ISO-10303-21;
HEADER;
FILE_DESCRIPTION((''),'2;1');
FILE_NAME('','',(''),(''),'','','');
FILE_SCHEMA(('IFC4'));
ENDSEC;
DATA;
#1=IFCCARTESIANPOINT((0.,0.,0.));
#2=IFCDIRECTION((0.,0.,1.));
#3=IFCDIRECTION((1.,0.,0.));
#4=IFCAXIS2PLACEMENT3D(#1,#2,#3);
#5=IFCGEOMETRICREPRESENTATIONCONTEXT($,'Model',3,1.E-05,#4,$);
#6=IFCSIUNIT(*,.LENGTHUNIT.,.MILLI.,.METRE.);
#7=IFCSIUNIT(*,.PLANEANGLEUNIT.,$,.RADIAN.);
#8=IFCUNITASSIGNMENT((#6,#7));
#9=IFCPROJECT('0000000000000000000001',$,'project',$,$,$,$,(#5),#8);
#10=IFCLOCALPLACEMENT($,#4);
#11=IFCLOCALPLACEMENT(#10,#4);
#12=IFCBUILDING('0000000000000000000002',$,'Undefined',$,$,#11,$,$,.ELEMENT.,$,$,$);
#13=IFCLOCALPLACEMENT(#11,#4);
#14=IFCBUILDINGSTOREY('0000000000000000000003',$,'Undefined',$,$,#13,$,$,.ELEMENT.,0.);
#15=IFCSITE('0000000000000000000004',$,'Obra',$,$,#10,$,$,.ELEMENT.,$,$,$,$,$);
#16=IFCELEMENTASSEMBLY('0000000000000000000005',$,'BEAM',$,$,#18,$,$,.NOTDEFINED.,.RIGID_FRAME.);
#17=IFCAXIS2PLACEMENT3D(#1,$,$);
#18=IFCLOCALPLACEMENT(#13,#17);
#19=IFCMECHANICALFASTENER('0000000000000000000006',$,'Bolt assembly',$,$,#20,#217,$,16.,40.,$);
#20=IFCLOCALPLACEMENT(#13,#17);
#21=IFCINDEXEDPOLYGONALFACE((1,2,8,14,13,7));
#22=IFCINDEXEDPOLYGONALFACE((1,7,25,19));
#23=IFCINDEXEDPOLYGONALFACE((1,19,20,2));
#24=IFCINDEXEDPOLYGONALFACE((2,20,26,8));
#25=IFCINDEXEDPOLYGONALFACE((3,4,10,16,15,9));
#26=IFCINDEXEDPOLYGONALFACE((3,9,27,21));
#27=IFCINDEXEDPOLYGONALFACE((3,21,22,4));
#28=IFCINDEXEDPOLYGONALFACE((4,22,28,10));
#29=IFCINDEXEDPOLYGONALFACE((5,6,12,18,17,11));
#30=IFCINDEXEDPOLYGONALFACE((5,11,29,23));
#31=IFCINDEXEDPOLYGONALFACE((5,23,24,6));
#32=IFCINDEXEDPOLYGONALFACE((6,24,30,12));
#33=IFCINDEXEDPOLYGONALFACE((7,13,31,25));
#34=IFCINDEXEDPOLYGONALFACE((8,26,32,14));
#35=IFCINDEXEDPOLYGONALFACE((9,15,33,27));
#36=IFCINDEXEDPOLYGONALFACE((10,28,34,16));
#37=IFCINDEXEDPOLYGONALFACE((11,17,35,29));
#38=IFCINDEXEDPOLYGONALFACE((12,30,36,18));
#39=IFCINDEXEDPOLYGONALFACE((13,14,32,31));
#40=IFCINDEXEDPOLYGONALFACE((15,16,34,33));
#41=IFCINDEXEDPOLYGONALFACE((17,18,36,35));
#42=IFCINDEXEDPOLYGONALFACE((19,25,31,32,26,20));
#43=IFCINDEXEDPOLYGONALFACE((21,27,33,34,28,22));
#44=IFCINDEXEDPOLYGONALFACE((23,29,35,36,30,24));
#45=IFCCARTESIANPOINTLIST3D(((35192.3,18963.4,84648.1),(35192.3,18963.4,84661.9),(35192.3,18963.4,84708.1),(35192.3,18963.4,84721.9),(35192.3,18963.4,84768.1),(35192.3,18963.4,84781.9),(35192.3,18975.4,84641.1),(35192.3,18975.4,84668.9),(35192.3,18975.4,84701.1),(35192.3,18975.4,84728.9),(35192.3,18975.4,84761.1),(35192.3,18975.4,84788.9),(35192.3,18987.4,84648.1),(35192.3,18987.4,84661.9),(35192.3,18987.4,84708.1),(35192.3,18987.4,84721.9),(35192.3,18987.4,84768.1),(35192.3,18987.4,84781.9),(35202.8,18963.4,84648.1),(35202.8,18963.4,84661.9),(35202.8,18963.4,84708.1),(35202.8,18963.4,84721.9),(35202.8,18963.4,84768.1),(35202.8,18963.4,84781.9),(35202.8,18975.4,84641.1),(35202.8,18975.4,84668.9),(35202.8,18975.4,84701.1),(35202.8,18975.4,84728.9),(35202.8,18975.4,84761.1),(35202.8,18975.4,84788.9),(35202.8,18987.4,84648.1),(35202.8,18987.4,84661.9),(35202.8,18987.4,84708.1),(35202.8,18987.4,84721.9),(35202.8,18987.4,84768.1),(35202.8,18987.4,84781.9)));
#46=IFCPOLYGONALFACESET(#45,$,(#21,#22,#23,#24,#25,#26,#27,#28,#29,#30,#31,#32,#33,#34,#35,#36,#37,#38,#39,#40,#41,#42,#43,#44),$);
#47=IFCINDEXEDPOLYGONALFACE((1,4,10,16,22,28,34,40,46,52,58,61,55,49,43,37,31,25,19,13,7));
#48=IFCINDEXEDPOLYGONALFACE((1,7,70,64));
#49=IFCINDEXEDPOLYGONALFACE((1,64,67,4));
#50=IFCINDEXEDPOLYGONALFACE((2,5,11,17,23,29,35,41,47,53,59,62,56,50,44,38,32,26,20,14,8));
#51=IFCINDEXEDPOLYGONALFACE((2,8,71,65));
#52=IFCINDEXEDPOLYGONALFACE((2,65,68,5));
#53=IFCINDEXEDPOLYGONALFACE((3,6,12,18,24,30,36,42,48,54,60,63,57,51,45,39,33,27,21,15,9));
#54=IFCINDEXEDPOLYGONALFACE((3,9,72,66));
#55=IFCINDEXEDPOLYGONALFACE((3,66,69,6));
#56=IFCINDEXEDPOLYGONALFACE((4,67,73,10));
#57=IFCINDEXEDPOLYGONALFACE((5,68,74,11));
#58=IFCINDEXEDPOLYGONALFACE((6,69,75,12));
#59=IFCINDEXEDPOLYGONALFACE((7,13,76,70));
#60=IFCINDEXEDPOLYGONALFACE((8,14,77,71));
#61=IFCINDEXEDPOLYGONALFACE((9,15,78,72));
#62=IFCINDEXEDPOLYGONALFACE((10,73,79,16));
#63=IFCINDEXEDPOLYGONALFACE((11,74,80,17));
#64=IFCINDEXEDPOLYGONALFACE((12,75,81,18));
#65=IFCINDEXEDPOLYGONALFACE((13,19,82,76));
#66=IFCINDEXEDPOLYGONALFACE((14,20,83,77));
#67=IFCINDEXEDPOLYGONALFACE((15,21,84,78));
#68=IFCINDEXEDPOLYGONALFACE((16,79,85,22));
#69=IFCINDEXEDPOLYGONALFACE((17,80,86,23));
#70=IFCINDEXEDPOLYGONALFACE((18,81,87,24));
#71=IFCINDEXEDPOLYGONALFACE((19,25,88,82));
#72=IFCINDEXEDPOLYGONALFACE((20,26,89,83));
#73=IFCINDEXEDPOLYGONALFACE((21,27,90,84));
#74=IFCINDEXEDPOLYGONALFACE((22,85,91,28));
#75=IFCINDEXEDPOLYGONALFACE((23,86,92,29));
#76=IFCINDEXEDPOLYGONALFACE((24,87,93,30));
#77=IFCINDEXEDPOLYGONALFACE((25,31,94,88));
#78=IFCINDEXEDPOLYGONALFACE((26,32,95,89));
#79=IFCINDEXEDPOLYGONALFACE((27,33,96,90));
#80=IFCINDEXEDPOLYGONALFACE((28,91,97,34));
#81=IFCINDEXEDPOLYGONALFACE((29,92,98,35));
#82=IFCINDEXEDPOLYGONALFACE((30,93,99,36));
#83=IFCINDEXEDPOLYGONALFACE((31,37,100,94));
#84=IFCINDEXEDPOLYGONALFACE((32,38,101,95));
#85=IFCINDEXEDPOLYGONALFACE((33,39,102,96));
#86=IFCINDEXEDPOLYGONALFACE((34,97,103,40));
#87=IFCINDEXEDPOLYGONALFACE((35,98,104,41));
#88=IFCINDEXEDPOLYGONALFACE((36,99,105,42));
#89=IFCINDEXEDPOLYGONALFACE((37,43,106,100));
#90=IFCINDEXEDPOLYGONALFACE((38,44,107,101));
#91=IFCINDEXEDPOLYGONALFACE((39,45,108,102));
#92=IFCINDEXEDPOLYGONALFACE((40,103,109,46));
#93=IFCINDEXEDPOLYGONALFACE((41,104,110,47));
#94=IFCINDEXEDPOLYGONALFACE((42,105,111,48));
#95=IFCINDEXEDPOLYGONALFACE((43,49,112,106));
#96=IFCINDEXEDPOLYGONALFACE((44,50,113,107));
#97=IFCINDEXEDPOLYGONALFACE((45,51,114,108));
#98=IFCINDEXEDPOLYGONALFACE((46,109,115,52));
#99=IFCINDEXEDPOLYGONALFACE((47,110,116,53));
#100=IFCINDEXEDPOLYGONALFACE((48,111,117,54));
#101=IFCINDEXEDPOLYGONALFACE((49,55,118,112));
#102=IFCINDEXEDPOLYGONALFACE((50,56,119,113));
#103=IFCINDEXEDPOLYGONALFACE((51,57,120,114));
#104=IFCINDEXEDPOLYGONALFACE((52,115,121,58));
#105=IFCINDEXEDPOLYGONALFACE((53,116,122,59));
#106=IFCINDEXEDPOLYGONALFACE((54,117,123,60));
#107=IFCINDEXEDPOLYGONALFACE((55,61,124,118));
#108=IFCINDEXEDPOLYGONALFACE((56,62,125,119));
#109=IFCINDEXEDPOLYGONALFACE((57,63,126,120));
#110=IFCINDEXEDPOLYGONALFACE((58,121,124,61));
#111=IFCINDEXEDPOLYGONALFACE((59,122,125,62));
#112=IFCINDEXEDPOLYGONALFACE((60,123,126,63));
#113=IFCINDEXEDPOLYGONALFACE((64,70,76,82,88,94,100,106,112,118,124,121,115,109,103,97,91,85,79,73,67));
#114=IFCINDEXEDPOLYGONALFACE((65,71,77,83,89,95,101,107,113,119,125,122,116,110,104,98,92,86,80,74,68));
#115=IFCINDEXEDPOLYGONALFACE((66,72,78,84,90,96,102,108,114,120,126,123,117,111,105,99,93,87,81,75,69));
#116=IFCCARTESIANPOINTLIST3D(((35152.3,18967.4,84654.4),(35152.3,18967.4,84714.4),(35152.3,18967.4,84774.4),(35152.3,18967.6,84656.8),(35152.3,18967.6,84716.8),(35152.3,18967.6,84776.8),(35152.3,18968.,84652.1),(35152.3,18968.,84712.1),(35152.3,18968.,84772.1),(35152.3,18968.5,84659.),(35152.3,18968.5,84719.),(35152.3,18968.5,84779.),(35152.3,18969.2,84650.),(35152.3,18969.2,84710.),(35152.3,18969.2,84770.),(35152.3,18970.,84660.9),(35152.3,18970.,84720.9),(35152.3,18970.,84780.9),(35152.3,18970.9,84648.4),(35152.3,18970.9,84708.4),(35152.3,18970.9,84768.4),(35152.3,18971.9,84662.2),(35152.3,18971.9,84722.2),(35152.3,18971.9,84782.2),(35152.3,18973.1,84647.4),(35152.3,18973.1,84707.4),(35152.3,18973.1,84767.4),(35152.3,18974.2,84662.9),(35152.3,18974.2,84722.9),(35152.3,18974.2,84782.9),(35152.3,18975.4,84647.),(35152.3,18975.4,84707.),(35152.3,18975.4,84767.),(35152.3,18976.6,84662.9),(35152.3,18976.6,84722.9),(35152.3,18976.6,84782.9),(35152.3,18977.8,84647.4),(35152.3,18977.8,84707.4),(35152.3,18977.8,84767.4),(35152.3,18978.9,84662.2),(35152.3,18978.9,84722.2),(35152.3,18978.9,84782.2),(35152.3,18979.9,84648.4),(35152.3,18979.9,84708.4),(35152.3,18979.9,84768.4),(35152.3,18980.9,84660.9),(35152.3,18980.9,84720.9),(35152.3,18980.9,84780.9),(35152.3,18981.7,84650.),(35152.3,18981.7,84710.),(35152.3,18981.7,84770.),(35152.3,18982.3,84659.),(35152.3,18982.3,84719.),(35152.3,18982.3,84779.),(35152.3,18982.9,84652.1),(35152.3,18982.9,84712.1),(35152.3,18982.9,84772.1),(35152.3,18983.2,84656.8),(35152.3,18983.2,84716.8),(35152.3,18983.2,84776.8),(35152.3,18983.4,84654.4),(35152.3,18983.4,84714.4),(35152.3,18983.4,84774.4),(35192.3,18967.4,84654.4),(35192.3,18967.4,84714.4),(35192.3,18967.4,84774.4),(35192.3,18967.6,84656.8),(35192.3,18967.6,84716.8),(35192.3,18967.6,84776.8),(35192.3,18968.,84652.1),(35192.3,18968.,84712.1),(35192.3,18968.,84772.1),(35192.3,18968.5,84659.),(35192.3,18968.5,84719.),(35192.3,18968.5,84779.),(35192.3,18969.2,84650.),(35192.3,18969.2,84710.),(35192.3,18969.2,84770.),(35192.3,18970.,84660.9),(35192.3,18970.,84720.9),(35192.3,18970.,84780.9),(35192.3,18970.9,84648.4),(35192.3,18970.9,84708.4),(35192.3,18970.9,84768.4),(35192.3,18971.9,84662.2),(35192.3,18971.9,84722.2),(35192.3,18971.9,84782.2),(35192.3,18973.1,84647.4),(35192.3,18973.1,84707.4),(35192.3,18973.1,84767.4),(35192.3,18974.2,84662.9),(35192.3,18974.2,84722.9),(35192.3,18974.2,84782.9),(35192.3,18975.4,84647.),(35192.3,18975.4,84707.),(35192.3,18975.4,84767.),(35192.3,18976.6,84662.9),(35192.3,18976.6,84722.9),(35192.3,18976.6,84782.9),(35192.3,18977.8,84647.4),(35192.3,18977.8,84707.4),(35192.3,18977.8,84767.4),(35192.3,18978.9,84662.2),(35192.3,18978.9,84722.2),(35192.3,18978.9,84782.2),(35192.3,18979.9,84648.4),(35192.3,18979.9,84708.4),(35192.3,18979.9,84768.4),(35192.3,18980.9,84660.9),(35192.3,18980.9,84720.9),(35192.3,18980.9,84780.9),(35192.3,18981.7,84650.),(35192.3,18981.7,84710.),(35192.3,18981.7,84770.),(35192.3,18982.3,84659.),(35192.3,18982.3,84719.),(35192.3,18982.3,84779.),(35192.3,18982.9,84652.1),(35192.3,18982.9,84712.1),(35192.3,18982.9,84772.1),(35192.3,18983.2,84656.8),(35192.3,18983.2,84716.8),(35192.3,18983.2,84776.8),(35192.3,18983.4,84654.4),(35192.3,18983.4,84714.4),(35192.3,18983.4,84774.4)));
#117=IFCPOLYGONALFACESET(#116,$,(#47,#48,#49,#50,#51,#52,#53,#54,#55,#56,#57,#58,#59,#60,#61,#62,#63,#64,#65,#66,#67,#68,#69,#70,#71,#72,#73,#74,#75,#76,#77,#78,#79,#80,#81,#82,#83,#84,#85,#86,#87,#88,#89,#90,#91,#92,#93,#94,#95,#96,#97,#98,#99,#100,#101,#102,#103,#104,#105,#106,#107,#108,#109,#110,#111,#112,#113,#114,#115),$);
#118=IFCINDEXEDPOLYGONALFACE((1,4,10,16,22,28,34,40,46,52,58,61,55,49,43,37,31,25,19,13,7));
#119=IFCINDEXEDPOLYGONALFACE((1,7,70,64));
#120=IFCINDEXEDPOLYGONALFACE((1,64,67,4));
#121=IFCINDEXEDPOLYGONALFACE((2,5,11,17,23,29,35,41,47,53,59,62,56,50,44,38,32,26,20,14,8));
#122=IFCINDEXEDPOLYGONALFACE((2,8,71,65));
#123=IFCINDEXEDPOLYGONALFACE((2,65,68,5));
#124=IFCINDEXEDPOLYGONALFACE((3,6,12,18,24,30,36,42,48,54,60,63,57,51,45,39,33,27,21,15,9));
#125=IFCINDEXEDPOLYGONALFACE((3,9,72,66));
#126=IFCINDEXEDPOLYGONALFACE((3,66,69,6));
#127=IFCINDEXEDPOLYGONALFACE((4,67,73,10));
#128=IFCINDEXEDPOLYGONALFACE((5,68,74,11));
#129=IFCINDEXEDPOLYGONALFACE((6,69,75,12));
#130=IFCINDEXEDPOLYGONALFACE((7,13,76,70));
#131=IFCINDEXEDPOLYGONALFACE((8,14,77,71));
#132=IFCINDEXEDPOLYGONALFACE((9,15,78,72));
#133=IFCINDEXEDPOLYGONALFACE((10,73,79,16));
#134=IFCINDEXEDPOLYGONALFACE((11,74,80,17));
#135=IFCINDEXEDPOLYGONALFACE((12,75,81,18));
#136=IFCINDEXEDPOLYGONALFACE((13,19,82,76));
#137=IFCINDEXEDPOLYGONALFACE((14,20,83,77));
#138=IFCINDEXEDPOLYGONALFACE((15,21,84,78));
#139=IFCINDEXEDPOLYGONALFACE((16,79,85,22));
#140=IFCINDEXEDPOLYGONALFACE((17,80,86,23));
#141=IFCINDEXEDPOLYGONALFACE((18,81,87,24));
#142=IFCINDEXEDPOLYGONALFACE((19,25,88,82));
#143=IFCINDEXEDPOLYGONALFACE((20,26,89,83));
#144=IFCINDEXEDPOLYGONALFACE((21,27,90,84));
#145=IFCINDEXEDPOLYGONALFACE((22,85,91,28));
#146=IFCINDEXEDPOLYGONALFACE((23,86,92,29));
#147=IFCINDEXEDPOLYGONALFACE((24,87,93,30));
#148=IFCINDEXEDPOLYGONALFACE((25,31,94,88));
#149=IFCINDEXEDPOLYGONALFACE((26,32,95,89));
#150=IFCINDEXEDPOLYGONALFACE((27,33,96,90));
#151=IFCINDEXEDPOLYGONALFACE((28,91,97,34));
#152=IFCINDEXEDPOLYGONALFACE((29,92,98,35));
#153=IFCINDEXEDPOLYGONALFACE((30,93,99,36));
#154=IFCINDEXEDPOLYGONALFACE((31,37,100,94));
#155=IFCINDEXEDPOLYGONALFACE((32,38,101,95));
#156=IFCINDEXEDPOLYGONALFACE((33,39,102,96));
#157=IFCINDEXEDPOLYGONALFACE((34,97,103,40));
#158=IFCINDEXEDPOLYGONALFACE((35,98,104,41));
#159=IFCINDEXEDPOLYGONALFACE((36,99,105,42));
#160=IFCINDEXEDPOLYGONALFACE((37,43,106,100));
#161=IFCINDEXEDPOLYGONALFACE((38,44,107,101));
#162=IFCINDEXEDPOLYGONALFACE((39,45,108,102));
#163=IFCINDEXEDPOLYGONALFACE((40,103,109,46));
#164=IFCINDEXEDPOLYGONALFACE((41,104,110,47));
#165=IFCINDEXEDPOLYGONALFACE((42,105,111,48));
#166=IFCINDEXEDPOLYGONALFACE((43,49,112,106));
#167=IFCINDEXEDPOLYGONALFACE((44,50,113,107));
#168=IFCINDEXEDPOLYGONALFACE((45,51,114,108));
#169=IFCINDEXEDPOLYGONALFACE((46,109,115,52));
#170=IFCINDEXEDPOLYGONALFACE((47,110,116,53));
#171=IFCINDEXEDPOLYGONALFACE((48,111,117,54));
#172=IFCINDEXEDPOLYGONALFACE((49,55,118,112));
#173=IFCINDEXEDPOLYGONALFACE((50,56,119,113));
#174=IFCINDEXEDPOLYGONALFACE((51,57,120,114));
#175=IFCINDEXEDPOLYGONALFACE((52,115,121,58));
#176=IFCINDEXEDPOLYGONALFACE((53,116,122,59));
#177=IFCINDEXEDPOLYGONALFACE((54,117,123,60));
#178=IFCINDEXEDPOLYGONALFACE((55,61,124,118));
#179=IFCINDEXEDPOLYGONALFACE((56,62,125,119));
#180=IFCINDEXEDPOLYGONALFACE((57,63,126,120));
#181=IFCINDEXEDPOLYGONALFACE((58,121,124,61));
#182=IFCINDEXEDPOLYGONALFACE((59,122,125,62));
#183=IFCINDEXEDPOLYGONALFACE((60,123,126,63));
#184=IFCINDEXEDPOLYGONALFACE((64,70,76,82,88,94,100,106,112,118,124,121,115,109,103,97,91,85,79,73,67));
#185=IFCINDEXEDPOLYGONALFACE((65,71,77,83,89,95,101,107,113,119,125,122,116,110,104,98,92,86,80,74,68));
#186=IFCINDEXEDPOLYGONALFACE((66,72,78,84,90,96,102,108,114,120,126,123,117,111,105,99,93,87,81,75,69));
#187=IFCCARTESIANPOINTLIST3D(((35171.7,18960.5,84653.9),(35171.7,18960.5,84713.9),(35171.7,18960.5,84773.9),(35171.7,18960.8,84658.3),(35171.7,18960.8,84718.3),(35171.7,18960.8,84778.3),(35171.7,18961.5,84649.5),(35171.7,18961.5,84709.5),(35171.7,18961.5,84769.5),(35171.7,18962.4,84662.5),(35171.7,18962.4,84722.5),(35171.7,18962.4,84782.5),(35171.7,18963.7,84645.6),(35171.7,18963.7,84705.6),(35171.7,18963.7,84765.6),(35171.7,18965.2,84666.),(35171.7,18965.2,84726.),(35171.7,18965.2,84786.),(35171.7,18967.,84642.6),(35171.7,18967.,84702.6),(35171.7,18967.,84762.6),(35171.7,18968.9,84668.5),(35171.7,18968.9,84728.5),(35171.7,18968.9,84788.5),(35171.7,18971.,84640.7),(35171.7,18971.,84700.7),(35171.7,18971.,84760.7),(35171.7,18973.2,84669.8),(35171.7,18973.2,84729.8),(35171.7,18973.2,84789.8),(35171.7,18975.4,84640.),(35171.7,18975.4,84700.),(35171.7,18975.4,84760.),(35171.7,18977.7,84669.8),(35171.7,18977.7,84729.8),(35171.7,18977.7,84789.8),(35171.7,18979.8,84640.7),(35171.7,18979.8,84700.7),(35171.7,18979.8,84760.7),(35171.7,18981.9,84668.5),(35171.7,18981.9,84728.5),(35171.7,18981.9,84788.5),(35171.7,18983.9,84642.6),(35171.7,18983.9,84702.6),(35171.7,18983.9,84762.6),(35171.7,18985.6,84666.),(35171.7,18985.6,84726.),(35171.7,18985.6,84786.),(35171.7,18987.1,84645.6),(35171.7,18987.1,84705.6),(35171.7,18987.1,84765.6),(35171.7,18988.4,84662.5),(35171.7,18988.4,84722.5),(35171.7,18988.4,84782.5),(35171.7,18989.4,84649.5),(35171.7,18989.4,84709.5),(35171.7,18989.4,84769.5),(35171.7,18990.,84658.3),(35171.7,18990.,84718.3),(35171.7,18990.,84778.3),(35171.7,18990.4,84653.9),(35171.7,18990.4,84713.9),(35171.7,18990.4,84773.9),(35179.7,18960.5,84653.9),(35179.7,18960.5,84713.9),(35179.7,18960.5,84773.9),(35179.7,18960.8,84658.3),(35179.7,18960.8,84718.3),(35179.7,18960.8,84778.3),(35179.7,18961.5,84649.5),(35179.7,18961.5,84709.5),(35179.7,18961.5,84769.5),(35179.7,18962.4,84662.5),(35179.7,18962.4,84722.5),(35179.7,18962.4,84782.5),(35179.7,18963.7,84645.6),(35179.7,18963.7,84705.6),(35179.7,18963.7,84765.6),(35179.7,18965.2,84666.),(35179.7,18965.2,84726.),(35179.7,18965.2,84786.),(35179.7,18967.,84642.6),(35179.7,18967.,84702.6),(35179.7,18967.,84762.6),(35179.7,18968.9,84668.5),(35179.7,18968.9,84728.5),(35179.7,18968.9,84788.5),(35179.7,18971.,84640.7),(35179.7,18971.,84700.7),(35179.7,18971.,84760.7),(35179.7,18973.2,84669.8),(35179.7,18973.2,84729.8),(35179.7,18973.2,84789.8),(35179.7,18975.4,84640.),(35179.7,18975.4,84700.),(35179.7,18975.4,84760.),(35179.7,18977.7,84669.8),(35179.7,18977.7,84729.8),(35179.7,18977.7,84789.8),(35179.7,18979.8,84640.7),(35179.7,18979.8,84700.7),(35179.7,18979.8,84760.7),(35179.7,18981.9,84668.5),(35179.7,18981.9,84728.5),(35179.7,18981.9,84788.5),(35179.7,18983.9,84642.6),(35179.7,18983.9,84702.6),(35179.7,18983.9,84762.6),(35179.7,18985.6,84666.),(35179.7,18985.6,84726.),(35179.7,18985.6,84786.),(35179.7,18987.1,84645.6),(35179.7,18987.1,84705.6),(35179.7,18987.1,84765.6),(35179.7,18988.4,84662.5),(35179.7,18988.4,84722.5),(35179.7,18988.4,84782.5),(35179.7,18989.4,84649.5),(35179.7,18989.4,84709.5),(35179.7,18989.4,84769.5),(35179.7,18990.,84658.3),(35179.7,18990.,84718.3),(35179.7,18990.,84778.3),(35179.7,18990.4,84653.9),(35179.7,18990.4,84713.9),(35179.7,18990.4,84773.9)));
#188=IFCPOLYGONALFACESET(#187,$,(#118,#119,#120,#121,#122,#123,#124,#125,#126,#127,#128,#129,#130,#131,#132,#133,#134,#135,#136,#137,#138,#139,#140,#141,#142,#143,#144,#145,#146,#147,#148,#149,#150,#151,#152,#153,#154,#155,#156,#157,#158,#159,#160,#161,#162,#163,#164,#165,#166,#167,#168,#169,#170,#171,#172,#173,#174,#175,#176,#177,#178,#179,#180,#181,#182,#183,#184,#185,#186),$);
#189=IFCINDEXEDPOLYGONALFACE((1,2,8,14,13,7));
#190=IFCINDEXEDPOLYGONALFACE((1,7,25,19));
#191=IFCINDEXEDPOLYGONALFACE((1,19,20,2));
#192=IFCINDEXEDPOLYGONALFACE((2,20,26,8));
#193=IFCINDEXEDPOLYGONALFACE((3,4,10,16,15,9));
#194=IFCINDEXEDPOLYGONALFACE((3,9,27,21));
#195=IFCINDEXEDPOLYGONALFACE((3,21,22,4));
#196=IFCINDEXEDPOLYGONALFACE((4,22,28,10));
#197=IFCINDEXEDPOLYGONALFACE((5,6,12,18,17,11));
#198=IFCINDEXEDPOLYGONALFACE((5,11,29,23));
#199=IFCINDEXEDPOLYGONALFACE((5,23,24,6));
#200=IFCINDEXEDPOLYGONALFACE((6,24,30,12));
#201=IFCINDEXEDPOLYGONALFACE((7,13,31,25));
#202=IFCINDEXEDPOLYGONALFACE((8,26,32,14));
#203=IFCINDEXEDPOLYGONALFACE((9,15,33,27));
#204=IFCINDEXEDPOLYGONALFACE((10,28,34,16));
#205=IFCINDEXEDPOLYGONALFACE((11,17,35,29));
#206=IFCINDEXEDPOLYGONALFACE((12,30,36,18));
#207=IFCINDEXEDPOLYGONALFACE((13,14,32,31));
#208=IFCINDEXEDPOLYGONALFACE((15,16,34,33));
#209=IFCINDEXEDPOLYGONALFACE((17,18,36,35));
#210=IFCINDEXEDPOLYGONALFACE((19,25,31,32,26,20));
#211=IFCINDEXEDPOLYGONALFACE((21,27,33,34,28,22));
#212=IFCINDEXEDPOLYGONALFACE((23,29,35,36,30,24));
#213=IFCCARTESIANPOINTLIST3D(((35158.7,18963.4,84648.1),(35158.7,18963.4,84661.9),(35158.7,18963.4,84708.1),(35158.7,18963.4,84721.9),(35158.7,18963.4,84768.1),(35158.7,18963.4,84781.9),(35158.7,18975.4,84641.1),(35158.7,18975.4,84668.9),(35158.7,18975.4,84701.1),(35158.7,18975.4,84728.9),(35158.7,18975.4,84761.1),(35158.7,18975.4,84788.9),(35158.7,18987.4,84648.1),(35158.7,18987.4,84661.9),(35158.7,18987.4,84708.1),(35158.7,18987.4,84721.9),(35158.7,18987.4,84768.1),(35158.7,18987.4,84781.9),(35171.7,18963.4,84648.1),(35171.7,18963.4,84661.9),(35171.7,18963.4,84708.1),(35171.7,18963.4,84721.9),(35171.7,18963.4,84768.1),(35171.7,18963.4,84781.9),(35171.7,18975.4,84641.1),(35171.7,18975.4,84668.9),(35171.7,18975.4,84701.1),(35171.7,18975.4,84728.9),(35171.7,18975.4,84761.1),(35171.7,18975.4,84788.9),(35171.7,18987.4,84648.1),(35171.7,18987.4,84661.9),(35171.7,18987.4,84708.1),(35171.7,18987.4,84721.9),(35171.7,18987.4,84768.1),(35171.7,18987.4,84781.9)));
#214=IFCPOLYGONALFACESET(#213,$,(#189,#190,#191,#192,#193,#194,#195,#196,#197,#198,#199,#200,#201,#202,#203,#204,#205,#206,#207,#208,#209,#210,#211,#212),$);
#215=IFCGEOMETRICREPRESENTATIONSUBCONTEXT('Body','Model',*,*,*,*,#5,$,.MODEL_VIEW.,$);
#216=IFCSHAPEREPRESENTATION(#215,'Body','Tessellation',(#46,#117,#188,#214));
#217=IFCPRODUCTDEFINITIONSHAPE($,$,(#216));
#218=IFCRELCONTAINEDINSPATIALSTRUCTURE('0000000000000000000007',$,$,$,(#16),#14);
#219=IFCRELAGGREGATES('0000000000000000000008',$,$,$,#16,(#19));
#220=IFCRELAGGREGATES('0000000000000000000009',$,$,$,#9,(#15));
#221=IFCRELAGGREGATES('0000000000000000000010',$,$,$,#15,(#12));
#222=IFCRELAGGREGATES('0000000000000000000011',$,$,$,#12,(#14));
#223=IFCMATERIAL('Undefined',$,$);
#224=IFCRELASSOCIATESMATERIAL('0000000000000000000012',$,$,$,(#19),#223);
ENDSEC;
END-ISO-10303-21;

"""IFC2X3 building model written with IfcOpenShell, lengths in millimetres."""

from ifc_helpers import new_model, si_unit, frame, origin_with_axes, origin_2d_with_axis, place, context, subcontext, project, spatial, polyline, circle, outline, extrude, source, transform, mapped, material, element, aggregate, save


model = new_model("IFC2X3")

# Units and contexts
model_context = context("Model", 3, precision=1e-05, world=origin_with_axes())
body_context = subcontext(model_context, "Body", "Model", "MODEL_VIEW")
ifc_project = project(units=[si_unit("LENGTHUNIT", "METRE", prefix="MILLI"), si_unit("PLANEANGLEUNIT", "RADIAN")], contexts=[model_context])

# Site, building, storey
site_placement = place(None, origin_with_axes())
site = spatial("IfcSite", under=ifc_project, at=site_placement, Name="Obra", CompositionType="ELEMENT")
building_placement = place(site_placement, origin_with_axes())
building = spatial("IfcBuilding", under=site, at=building_placement, Name="Undefined", CompositionType="ELEMENT")
storey_placement = place(building_placement, origin_with_axes())
storey = spatial("IfcBuildingStorey", under=building, at=storey_placement, Name="Undefined", CompositionType="ELEMENT", Elevation=0.0)

# Shared definitions
ifc_material_1 = material(Name="Undefined")
shared_shape_1 = source(origin_with_axes(), body_context, "Body", "SweptSolid", [
    extrude(outline(polyline([(13.9, 0.0), (6.9, 12.0), (-6.9, 12.0), (-13.9, 0.0), (-6.9, -12.0), (6.9, -12.0), (13.9, 0.0)])), frame((0.0, -19.9, 0.0), z_axis=(0.0, 1.0, 0.0), x_axis=(1.0, 0.0, 0.0)), (0.0, 0.0, 1.0), 10.6),
    extrude(circle(Radius=8.0, at=origin_2d_with_axis()), frame((0.0, -9.3, 0.0), z_axis=(0.0, 1.0, 0.0), x_axis=(1.0, 0.0, 0.0)), (0.0, 0.0, 1.0), 40.0),
    extrude(circle(Radius=15.0, at=origin_2d_with_axis()), frame((0.0, 3.3, 0.0), z_axis=(0.0, 1.0, 0.0), x_axis=(1.0, 0.0, 0.0)), (0.0, 0.0, 1.0), 8.0),
    extrude(outline(polyline([(13.9, 0.0), (6.9, 12.0), (-6.9, 12.0), (-13.9, 0.0), (-6.9, -12.0), (6.9, -12.0), (13.9, 0.0)])), frame((0.0, 11.3, 0.0), z_axis=(0.0, 1.0, 0.0), x_axis=(1.0, 0.0, 0.0)), (0.0, 0.0, 1.0), 13.0),
])

# Element assembly, mechanical fastener
assembly_1_placement = place(storey_placement, origin_with_axes())
assembly_1 = element("IfcElementAssembly", 1, at=assembly_1_placement, inside=storey, Name="BEAM", AssemblyPlace="NOTDEFINED", PredefinedType="RIGID_FRAME")
mechanical_fastener_1_placement = place(assembly_1_placement, frame((35183.0, 18925.4, 84850.0), z_axis=(0.0, 1.0, 0.0), x_axis=(0.0, 0.0, -1.0)))
mechanical_fastener_1 = element("IfcMechanicalFastener", 2, at=mechanical_fastener_1_placement, material=ifc_material_1, Name="Bolt assembly", NominalDiameter=16.0, NominalLength=40.0, context=body_context, shape_type="MappedRepresentation", body=[
    mapped(shared_shape_1, transform((75.0, 0.0, 50.0))),
    mapped(shared_shape_1, transform((135.0, 0.0, 50.0))),
    mapped(shared_shape_1, transform((195.0, 0.0, 50.0))),
])
aggregate(assembly_1, [mechanical_fastener_1])

save(model, "model.ifc")
